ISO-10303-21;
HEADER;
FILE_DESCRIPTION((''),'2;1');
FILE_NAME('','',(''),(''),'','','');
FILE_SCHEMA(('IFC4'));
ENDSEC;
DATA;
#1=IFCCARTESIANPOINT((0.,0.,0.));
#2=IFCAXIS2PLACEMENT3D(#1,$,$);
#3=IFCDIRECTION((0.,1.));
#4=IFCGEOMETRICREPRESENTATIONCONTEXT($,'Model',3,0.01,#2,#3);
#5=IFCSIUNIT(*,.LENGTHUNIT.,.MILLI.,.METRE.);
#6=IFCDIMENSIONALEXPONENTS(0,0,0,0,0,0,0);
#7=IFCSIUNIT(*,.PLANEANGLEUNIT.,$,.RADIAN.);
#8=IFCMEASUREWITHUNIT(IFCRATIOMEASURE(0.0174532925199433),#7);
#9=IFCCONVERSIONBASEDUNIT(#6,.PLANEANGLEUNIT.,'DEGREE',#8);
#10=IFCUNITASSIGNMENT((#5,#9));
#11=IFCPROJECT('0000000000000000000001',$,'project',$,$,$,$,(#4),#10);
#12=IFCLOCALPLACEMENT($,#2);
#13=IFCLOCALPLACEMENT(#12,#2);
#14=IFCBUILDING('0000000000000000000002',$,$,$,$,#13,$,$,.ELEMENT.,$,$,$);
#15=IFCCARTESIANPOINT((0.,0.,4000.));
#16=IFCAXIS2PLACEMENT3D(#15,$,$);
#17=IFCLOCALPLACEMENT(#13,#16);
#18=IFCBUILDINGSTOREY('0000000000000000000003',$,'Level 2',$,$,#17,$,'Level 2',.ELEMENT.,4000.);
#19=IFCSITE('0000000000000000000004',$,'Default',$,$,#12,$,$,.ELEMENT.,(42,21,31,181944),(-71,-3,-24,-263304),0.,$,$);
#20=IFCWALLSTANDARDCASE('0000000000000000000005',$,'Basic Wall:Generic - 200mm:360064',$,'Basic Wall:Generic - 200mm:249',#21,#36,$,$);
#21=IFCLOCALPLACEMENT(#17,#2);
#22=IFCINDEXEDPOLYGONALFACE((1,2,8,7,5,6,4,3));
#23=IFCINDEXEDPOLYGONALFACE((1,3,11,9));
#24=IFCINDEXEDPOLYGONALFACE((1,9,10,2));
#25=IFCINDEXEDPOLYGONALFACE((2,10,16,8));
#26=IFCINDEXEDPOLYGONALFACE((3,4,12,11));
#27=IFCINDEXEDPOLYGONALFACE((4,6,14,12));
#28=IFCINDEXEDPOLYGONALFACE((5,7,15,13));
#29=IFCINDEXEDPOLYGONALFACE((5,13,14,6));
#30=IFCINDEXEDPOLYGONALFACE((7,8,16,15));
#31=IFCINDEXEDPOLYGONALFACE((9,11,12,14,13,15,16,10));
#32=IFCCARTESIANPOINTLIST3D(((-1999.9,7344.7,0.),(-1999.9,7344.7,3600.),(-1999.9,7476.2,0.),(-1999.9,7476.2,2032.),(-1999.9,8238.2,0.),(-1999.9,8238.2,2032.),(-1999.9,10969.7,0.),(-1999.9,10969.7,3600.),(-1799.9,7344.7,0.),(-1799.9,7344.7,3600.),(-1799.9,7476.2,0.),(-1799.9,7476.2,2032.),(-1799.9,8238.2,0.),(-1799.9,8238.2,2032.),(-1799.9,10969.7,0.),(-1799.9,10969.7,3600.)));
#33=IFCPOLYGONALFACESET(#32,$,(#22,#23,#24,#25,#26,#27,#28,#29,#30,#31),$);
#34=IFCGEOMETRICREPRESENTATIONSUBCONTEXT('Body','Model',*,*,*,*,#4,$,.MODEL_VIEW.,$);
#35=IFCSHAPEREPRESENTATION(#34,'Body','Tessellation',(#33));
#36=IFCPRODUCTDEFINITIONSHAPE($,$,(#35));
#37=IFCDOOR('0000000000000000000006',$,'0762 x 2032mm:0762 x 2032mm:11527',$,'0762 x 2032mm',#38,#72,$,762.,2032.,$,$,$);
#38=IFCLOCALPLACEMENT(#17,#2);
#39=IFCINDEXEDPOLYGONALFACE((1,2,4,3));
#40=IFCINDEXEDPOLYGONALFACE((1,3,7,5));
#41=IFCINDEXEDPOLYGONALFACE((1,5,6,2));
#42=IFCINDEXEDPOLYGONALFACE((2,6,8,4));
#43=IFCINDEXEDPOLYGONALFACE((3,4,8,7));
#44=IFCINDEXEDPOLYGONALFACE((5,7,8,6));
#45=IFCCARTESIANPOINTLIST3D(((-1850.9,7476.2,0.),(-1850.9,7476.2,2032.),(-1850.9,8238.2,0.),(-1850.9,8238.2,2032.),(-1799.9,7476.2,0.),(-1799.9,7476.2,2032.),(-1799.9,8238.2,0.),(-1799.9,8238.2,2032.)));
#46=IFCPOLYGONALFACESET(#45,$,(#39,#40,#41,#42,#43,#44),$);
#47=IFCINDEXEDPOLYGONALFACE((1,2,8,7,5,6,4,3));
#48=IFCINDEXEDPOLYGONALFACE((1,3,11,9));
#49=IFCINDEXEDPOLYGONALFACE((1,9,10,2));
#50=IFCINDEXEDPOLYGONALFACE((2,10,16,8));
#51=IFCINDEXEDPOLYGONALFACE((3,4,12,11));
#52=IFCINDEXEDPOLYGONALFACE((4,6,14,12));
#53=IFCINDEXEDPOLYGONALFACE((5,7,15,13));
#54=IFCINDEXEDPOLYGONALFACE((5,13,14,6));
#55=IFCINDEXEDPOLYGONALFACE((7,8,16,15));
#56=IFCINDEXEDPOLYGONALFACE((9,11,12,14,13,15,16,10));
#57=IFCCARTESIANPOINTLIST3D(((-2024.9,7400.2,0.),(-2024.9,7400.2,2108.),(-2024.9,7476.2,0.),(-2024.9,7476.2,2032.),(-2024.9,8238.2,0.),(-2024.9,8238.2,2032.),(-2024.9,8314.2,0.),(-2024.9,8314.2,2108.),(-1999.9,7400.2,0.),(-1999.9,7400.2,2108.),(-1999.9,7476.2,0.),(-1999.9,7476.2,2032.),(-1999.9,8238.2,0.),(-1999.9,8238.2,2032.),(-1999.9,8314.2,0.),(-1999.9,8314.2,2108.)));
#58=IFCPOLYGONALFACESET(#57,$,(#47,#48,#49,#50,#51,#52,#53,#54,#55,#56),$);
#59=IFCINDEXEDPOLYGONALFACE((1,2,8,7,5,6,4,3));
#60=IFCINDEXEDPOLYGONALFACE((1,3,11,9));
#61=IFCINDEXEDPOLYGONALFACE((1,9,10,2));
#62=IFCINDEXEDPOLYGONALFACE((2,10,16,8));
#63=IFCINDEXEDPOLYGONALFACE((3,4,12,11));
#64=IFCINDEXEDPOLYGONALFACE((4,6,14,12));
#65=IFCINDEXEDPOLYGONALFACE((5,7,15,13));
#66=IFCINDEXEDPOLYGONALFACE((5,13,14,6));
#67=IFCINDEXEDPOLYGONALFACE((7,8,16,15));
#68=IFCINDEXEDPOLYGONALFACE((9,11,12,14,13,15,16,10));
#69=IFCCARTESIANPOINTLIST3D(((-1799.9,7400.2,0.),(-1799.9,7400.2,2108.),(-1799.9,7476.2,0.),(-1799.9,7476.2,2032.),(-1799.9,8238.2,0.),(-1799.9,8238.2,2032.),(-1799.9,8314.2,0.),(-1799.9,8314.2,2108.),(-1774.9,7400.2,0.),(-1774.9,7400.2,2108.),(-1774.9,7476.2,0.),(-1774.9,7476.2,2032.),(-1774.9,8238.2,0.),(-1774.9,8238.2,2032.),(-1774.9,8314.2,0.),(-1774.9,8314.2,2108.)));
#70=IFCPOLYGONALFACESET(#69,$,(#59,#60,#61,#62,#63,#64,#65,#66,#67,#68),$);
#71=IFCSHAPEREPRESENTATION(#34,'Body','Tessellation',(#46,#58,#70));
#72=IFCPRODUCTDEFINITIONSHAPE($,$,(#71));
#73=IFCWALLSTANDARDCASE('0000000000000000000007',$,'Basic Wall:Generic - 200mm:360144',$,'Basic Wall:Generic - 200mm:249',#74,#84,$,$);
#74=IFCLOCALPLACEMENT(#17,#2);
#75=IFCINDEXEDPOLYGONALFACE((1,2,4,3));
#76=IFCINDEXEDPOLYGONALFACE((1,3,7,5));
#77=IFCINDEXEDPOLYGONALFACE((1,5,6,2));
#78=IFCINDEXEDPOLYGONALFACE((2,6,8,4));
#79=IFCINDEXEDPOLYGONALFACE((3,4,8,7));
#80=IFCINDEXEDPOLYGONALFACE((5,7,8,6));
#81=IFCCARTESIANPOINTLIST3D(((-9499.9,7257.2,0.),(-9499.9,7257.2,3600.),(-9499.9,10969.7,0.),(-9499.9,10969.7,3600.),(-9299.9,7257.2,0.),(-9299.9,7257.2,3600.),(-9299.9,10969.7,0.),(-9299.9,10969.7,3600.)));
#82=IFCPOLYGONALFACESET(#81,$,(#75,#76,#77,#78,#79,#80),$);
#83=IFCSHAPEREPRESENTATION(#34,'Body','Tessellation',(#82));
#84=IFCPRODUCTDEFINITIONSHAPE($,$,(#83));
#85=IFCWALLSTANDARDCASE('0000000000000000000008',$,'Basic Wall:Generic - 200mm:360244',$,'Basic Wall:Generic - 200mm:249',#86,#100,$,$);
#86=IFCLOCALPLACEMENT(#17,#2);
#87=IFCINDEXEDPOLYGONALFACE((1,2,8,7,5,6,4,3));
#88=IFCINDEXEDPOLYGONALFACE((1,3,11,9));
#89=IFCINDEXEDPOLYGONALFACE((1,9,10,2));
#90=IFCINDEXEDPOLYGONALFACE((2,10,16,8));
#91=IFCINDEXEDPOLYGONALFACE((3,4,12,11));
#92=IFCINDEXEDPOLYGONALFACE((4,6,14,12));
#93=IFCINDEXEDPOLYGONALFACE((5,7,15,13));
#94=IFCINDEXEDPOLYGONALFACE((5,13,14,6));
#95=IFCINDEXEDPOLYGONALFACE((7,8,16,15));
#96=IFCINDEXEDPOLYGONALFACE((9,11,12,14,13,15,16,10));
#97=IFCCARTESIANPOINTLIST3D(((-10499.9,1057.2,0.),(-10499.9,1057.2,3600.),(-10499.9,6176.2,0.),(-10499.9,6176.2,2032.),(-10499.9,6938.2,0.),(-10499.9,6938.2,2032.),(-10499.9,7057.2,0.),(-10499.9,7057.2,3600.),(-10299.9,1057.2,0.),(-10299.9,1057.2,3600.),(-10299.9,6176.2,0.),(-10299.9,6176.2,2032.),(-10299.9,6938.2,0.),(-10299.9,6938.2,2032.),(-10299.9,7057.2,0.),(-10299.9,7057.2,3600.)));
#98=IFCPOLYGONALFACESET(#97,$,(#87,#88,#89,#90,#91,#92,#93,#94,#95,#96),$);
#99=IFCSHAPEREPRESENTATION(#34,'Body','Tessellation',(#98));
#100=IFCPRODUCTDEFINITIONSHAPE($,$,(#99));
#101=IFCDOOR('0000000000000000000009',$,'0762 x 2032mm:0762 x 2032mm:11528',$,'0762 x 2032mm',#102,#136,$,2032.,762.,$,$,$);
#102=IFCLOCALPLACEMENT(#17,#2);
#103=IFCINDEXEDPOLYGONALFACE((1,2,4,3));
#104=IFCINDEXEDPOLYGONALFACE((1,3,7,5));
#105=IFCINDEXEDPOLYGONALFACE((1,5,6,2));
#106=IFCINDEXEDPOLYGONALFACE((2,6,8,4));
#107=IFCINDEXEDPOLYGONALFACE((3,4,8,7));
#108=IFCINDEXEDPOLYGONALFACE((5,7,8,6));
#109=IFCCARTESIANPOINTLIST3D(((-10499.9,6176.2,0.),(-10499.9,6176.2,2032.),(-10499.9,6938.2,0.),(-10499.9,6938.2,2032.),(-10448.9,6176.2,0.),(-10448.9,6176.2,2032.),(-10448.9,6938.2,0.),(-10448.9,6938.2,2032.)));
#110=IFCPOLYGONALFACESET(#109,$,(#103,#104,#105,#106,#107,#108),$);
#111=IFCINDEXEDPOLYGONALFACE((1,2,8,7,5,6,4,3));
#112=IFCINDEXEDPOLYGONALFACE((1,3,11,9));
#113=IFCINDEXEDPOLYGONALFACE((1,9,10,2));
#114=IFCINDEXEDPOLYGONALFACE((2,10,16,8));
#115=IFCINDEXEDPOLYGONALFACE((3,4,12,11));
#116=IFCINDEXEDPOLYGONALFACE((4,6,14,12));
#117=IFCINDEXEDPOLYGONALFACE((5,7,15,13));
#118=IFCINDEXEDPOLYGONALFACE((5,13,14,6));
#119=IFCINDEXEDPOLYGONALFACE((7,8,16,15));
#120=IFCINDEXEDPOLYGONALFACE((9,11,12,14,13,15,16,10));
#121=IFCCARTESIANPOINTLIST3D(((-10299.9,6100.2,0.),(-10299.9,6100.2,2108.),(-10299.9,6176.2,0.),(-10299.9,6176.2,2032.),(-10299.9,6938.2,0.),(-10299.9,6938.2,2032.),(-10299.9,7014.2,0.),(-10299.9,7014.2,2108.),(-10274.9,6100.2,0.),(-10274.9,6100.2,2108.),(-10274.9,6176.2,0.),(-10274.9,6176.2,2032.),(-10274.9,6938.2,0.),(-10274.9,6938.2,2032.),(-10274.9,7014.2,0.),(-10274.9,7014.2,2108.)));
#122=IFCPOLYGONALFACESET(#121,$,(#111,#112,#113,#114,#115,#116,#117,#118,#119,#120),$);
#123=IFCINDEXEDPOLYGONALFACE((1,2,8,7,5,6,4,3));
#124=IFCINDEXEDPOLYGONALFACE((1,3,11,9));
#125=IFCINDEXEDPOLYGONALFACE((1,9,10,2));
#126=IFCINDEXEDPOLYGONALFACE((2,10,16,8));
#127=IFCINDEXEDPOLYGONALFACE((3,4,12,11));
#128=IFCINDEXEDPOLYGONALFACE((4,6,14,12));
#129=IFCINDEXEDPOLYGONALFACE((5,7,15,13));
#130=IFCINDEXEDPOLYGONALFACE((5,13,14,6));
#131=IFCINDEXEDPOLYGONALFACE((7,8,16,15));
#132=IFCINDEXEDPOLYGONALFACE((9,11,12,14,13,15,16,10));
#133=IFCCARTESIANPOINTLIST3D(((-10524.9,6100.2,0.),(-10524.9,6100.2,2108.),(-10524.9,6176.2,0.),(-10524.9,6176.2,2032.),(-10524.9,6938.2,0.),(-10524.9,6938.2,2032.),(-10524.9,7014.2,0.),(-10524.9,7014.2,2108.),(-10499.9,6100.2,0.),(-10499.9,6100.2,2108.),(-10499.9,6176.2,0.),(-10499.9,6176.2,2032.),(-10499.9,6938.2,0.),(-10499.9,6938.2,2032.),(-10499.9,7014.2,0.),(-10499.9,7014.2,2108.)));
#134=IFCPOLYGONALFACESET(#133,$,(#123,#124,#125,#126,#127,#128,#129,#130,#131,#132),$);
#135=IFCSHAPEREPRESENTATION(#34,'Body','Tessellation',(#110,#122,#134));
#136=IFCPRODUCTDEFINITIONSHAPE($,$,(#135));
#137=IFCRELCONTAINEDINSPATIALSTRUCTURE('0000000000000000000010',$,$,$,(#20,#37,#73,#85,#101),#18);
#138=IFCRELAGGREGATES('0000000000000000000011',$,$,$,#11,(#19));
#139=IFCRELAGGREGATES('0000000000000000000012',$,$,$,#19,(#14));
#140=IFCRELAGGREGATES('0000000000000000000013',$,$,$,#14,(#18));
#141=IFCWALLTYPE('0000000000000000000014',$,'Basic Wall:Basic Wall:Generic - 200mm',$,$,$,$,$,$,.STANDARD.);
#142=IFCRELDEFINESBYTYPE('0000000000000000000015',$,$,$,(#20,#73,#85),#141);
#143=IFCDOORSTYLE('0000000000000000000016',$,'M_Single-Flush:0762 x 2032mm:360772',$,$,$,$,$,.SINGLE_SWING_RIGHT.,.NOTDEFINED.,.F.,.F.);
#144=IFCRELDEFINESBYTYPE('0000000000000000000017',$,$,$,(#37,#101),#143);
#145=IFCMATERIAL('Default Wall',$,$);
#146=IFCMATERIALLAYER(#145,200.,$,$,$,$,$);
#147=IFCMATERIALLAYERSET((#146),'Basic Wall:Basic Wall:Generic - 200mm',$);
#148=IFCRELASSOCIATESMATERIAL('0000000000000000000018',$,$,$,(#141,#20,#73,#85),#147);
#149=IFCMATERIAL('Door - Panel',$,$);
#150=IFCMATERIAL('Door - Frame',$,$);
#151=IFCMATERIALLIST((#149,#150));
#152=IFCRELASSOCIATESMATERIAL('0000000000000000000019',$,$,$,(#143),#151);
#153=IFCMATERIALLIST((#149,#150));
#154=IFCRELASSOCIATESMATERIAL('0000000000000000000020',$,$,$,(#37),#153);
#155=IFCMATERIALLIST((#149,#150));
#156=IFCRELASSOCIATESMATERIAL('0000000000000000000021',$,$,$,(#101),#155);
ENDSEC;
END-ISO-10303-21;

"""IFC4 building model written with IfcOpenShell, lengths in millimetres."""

from ifc_helpers import new_model, entity, si_unit, converted_unit, direction, frame, frame_2d, origin, place, context, subcontext, project, spatial, polyline, rectangle, outline, extrude, source, transform, mapped, material, material_list, layer, layer_set, layer_usage, type_object, type_shapes, element, fill, save


model = new_model("IFC4")

# Units and contexts
model_context = context("Model", 3, precision=0.01, world=origin(), true_north=direction((0.0, 1.0)))
body_context = subcontext(model_context, "Body", "Model", "MODEL_VIEW")
ifc_project = project(units=[si_unit("LENGTHUNIT", "METRE", prefix="MILLI"), converted_unit("PLANEANGLEUNIT", "DEGREE", entity("IfcRatioMeasure", 0.0174532925199433), si_unit("PLANEANGLEUNIT", "RADIAN"), dimensions=[0, 0, 0, 0, 0, 0, 0])], contexts=[model_context])

# Site, building, storey
site_placement = place(None, origin())
site = spatial("IfcSite", under=ifc_project, at=site_placement, Name="Default", CompositionType="ELEMENT", RefLatitude=(42, 21, 31, 181944), RefLongitude=(-71, -3, -24, -263304), RefElevation=0.0)
building_placement = place(site_placement, origin())
building = spatial("IfcBuilding", under=site, at=building_placement, CompositionType="ELEMENT")
storey_placement = place(building_placement, frame((0.0, 0.0, 4000.0)))
storey = spatial("IfcBuildingStorey", under=building, at=storey_placement, Name="Level 2", LongName="Level 2", CompositionType="ELEMENT", Elevation=4000.0)

# Shared definitions
ifc_material_1 = material(Name="Default Wall")
ifc_material_2 = material(Name="Door - Panel")
ifc_material_3 = material(Name="Door - Frame")

# Shared definitions
ifc_layer_1 = layer(ifc_material_1, 200.0)
ifc_layer_set_1 = layer_set([ifc_layer_1], Name="Basic Wall:Basic Wall:Generic - 200mm")
wall_type_1 = type_object("IfcWallType", Name="Basic Wall:Basic Wall:Generic - 200mm", PredefinedType="STANDARD", material=ifc_layer_set_1)

# Shared definitions
ifc_material_list_1 = material_list([ifc_material_2, ifc_material_3])
door_style_1 = type_object("IfcDoorStyle", Name="M_Single-Flush:0762 x 2032mm:360772", ConstructionType="NOTDEFINED", OperationType="SINGLE_SWING_RIGHT", ParameterTakesPrecedence=False, Sizeable=False, material=ifc_material_list_1)
shared_shape_1 = source(origin(), body_context, "Body", "SweptSolid", [
    extrude(rectangle(XDim=762.0, YDim=51.0, at=frame_2d((0.0, 0.0), x_axis=(1.0, 0.0))), frame((381.0, -27.5, 0.0), z_axis=(0.0, 0.0, 1.0), x_axis=(-1.0, 0.0, 0.0)), (0.0, 0.0, 1.0), 2032.0),
    extrude(outline(polyline([(-457.0, -1035.0), (-381.0, -1035.0), (-381.0, 997.0), (381.0, 997.0), (381.0, -1035.0), (457.0, -1035.0), (457.0, 1073.0), (-457.0, 1073.0), (-457.0, -1035.0)])), frame((381.0, -227.0, 1035.0), z_axis=(0.0, 1.0, 0.0), x_axis=(-1.0, 0.0, 0.0)), (0.0, 0.0, 1.0), 25.0),
    extrude(outline(polyline([(-1073.0, -457.0), (1035.0, -457.0), (1035.0, -381.0), (-997.0, -381.0), (-997.0, 381.0), (1035.0, 381.0), (1035.0, 457.0), (-1073.0, 457.0), (-1073.0, -457.0)])), frame((381.0, -2.0, 1035.0), z_axis=(0.0, 1.0, 0.0), x_axis=(0.0, 0.0, -1.0)), (0.0, 0.0, 1.0), 25.0),
])
type_shapes(door_style_1, [shared_shape_1])

# Wall, opening, door
ifc_layer_usage_1 = layer_usage(ifc_layer_set_1, "AXIS2", "NEGATIVE", 100.0)
wall_1_placement = place(storey_placement, frame((-1899.9, 10969.7, 0.0), z_axis=(0.0, 0.0, 1.0), x_axis=(0.0, -1.0, 0.0)))
wall_1 = element("IfcWallStandardCase", 1, at=wall_1_placement, inside=storey, type_object=wall_type_1, material=ifc_layer_usage_1, Name="Basic Wall:Generic - 200mm:360064", ObjectType="Basic Wall:Generic - 200mm:249", context=body_context, shape_type="SweptSolid", body=[
    extrude(rectangle(XDim=3625.0, YDim=200.0, at=frame_2d((1812.5, 0.0), x_axis=(-1.0, 0.0))), origin(), (0.0, 0.0, 1.0), 3600.0),
])
opening_1_placement = place(wall_1_placement, frame((10969.7, 1899.9, 0.0), z_axis=(0.0, 0.0, 1.0), x_axis=(0.0, 1.0, 0.0)))
opening_1 = element("IfcOpeningElement", 2, at=opening_1_placement, cuts=wall_1, ObjectType="Opening", context=body_context, shape_type="SweptSolid", body=[
    extrude(rectangle(XDim=2032.0, YDim=762.0, at=frame_2d((0.0, 0.0), x_axis=(1.0, 0.0))), frame((-2001.9, 7857.2, 1016.0), z_axis=(1.0, 0.0, 0.0), x_axis=(0.0, 0.0, -1.0)), (0.0, 0.0, 1.0), 204.0),
])
ifc_material_list_2 = material_list([ifc_material_2, ifc_material_3])
door_1_placement = place(opening_1_placement, frame((-1797.9, 8238.2, 0.0), z_axis=(0.0, 0.0, 1.0), x_axis=(0.0, -1.0, 0.0)))
door_1 = element("IfcDoor", 3, at=door_1_placement, inside=storey, type_object=door_style_1, material=ifc_material_list_2, Name="0762 x 2032mm:0762 x 2032mm:11527", ObjectType="0762 x 2032mm", OverallHeight=762.0, OverallWidth=2032.0, context=body_context, shape_type="MappedRepresentation", body=[
    mapped(shared_shape_1, transform((0.0, 0.0, 0.0), scale=1.0)),
])
fill(opening_1, door_1)

# Wall
ifc_layer_usage_2 = layer_usage(ifc_layer_set_1, "AXIS2", "NEGATIVE", 100.0)
wall_2_placement = place(storey_placement, frame((-9399.9, 7257.2, 0.0), z_axis=(0.0, 0.0, 1.0), x_axis=(0.0, 1.0, 0.0)))
element("IfcWallStandardCase", 4, at=wall_2_placement, inside=storey, type_object=wall_type_1, material=ifc_layer_usage_2, Name="Basic Wall:Generic - 200mm:360144", ObjectType="Basic Wall:Generic - 200mm:249", context=body_context, shape_type="SweptSolid", body=[
    extrude(rectangle(XDim=3712.5, YDim=200.0, at=frame_2d((1856.2, 0.0), x_axis=(-1.0, 0.0))), origin(), (0.0, 0.0, 1.0), 3600.0),
])

# Wall, opening, door
ifc_layer_usage_3 = layer_usage(ifc_layer_set_1, "AXIS2", "NEGATIVE", 100.0)
wall_3_placement = place(storey_placement, frame((-10399.9, 7057.2, 0.0), z_axis=(0.0, 0.0, 1.0), x_axis=(0.0, -1.0, 0.0)))
wall_3 = element("IfcWallStandardCase", 5, at=wall_3_placement, inside=storey, type_object=wall_type_1, material=ifc_layer_usage_3, Name="Basic Wall:Generic - 200mm:360244", ObjectType="Basic Wall:Generic - 200mm:249", context=body_context, shape_type="SweptSolid", body=[
    extrude(rectangle(XDim=6000.0, YDim=200.0, at=frame_2d((3000.0, 0.0), x_axis=(-1.0, 0.0))), origin(), (0.0, 0.0, 1.0), 3600.0),
])
opening_2_placement = place(wall_3_placement, frame((7057.2, 10399.9, 0.0), z_axis=(0.0, 0.0, 1.0), x_axis=(0.0, 1.0, 0.0)))
opening_2 = element("IfcOpeningElement", 6, at=opening_2_placement, cuts=wall_3, ObjectType="Opening", context=body_context, shape_type="SweptSolid", body=[
    extrude(rectangle(XDim=2032.0, YDim=762.0, at=frame_2d((0.0, 0.0), x_axis=(0.0, 1.0))), frame((-10501.9, 6557.2, 1016.0), z_axis=(1.0, 0.0, 0.0), x_axis=(0.0, -1.0, 0.0)), (0.0, 0.0, 1.0), 204.0),
])
ifc_material_list_3 = material_list([ifc_material_2, ifc_material_3])
door_2_placement = place(opening_2_placement, frame((-10501.9, 6176.2, 0.0), z_axis=(0.0, 0.0, 1.0), x_axis=(0.0, 1.0, 0.0)))
door_2 = element("IfcDoor", 7, at=door_2_placement, inside=storey, type_object=door_style_1, material=ifc_material_list_3, Name="0762 x 2032mm:0762 x 2032mm:11528", ObjectType="0762 x 2032mm", OverallHeight=2032.0, OverallWidth=762.0, context=body_context, shape_type="MappedRepresentation", body=[
    mapped(shared_shape_1, transform((0.0, 0.0, 0.0), scale=1.0)),
])
fill(opening_2, door_2)

save(model, "model.ifc")
